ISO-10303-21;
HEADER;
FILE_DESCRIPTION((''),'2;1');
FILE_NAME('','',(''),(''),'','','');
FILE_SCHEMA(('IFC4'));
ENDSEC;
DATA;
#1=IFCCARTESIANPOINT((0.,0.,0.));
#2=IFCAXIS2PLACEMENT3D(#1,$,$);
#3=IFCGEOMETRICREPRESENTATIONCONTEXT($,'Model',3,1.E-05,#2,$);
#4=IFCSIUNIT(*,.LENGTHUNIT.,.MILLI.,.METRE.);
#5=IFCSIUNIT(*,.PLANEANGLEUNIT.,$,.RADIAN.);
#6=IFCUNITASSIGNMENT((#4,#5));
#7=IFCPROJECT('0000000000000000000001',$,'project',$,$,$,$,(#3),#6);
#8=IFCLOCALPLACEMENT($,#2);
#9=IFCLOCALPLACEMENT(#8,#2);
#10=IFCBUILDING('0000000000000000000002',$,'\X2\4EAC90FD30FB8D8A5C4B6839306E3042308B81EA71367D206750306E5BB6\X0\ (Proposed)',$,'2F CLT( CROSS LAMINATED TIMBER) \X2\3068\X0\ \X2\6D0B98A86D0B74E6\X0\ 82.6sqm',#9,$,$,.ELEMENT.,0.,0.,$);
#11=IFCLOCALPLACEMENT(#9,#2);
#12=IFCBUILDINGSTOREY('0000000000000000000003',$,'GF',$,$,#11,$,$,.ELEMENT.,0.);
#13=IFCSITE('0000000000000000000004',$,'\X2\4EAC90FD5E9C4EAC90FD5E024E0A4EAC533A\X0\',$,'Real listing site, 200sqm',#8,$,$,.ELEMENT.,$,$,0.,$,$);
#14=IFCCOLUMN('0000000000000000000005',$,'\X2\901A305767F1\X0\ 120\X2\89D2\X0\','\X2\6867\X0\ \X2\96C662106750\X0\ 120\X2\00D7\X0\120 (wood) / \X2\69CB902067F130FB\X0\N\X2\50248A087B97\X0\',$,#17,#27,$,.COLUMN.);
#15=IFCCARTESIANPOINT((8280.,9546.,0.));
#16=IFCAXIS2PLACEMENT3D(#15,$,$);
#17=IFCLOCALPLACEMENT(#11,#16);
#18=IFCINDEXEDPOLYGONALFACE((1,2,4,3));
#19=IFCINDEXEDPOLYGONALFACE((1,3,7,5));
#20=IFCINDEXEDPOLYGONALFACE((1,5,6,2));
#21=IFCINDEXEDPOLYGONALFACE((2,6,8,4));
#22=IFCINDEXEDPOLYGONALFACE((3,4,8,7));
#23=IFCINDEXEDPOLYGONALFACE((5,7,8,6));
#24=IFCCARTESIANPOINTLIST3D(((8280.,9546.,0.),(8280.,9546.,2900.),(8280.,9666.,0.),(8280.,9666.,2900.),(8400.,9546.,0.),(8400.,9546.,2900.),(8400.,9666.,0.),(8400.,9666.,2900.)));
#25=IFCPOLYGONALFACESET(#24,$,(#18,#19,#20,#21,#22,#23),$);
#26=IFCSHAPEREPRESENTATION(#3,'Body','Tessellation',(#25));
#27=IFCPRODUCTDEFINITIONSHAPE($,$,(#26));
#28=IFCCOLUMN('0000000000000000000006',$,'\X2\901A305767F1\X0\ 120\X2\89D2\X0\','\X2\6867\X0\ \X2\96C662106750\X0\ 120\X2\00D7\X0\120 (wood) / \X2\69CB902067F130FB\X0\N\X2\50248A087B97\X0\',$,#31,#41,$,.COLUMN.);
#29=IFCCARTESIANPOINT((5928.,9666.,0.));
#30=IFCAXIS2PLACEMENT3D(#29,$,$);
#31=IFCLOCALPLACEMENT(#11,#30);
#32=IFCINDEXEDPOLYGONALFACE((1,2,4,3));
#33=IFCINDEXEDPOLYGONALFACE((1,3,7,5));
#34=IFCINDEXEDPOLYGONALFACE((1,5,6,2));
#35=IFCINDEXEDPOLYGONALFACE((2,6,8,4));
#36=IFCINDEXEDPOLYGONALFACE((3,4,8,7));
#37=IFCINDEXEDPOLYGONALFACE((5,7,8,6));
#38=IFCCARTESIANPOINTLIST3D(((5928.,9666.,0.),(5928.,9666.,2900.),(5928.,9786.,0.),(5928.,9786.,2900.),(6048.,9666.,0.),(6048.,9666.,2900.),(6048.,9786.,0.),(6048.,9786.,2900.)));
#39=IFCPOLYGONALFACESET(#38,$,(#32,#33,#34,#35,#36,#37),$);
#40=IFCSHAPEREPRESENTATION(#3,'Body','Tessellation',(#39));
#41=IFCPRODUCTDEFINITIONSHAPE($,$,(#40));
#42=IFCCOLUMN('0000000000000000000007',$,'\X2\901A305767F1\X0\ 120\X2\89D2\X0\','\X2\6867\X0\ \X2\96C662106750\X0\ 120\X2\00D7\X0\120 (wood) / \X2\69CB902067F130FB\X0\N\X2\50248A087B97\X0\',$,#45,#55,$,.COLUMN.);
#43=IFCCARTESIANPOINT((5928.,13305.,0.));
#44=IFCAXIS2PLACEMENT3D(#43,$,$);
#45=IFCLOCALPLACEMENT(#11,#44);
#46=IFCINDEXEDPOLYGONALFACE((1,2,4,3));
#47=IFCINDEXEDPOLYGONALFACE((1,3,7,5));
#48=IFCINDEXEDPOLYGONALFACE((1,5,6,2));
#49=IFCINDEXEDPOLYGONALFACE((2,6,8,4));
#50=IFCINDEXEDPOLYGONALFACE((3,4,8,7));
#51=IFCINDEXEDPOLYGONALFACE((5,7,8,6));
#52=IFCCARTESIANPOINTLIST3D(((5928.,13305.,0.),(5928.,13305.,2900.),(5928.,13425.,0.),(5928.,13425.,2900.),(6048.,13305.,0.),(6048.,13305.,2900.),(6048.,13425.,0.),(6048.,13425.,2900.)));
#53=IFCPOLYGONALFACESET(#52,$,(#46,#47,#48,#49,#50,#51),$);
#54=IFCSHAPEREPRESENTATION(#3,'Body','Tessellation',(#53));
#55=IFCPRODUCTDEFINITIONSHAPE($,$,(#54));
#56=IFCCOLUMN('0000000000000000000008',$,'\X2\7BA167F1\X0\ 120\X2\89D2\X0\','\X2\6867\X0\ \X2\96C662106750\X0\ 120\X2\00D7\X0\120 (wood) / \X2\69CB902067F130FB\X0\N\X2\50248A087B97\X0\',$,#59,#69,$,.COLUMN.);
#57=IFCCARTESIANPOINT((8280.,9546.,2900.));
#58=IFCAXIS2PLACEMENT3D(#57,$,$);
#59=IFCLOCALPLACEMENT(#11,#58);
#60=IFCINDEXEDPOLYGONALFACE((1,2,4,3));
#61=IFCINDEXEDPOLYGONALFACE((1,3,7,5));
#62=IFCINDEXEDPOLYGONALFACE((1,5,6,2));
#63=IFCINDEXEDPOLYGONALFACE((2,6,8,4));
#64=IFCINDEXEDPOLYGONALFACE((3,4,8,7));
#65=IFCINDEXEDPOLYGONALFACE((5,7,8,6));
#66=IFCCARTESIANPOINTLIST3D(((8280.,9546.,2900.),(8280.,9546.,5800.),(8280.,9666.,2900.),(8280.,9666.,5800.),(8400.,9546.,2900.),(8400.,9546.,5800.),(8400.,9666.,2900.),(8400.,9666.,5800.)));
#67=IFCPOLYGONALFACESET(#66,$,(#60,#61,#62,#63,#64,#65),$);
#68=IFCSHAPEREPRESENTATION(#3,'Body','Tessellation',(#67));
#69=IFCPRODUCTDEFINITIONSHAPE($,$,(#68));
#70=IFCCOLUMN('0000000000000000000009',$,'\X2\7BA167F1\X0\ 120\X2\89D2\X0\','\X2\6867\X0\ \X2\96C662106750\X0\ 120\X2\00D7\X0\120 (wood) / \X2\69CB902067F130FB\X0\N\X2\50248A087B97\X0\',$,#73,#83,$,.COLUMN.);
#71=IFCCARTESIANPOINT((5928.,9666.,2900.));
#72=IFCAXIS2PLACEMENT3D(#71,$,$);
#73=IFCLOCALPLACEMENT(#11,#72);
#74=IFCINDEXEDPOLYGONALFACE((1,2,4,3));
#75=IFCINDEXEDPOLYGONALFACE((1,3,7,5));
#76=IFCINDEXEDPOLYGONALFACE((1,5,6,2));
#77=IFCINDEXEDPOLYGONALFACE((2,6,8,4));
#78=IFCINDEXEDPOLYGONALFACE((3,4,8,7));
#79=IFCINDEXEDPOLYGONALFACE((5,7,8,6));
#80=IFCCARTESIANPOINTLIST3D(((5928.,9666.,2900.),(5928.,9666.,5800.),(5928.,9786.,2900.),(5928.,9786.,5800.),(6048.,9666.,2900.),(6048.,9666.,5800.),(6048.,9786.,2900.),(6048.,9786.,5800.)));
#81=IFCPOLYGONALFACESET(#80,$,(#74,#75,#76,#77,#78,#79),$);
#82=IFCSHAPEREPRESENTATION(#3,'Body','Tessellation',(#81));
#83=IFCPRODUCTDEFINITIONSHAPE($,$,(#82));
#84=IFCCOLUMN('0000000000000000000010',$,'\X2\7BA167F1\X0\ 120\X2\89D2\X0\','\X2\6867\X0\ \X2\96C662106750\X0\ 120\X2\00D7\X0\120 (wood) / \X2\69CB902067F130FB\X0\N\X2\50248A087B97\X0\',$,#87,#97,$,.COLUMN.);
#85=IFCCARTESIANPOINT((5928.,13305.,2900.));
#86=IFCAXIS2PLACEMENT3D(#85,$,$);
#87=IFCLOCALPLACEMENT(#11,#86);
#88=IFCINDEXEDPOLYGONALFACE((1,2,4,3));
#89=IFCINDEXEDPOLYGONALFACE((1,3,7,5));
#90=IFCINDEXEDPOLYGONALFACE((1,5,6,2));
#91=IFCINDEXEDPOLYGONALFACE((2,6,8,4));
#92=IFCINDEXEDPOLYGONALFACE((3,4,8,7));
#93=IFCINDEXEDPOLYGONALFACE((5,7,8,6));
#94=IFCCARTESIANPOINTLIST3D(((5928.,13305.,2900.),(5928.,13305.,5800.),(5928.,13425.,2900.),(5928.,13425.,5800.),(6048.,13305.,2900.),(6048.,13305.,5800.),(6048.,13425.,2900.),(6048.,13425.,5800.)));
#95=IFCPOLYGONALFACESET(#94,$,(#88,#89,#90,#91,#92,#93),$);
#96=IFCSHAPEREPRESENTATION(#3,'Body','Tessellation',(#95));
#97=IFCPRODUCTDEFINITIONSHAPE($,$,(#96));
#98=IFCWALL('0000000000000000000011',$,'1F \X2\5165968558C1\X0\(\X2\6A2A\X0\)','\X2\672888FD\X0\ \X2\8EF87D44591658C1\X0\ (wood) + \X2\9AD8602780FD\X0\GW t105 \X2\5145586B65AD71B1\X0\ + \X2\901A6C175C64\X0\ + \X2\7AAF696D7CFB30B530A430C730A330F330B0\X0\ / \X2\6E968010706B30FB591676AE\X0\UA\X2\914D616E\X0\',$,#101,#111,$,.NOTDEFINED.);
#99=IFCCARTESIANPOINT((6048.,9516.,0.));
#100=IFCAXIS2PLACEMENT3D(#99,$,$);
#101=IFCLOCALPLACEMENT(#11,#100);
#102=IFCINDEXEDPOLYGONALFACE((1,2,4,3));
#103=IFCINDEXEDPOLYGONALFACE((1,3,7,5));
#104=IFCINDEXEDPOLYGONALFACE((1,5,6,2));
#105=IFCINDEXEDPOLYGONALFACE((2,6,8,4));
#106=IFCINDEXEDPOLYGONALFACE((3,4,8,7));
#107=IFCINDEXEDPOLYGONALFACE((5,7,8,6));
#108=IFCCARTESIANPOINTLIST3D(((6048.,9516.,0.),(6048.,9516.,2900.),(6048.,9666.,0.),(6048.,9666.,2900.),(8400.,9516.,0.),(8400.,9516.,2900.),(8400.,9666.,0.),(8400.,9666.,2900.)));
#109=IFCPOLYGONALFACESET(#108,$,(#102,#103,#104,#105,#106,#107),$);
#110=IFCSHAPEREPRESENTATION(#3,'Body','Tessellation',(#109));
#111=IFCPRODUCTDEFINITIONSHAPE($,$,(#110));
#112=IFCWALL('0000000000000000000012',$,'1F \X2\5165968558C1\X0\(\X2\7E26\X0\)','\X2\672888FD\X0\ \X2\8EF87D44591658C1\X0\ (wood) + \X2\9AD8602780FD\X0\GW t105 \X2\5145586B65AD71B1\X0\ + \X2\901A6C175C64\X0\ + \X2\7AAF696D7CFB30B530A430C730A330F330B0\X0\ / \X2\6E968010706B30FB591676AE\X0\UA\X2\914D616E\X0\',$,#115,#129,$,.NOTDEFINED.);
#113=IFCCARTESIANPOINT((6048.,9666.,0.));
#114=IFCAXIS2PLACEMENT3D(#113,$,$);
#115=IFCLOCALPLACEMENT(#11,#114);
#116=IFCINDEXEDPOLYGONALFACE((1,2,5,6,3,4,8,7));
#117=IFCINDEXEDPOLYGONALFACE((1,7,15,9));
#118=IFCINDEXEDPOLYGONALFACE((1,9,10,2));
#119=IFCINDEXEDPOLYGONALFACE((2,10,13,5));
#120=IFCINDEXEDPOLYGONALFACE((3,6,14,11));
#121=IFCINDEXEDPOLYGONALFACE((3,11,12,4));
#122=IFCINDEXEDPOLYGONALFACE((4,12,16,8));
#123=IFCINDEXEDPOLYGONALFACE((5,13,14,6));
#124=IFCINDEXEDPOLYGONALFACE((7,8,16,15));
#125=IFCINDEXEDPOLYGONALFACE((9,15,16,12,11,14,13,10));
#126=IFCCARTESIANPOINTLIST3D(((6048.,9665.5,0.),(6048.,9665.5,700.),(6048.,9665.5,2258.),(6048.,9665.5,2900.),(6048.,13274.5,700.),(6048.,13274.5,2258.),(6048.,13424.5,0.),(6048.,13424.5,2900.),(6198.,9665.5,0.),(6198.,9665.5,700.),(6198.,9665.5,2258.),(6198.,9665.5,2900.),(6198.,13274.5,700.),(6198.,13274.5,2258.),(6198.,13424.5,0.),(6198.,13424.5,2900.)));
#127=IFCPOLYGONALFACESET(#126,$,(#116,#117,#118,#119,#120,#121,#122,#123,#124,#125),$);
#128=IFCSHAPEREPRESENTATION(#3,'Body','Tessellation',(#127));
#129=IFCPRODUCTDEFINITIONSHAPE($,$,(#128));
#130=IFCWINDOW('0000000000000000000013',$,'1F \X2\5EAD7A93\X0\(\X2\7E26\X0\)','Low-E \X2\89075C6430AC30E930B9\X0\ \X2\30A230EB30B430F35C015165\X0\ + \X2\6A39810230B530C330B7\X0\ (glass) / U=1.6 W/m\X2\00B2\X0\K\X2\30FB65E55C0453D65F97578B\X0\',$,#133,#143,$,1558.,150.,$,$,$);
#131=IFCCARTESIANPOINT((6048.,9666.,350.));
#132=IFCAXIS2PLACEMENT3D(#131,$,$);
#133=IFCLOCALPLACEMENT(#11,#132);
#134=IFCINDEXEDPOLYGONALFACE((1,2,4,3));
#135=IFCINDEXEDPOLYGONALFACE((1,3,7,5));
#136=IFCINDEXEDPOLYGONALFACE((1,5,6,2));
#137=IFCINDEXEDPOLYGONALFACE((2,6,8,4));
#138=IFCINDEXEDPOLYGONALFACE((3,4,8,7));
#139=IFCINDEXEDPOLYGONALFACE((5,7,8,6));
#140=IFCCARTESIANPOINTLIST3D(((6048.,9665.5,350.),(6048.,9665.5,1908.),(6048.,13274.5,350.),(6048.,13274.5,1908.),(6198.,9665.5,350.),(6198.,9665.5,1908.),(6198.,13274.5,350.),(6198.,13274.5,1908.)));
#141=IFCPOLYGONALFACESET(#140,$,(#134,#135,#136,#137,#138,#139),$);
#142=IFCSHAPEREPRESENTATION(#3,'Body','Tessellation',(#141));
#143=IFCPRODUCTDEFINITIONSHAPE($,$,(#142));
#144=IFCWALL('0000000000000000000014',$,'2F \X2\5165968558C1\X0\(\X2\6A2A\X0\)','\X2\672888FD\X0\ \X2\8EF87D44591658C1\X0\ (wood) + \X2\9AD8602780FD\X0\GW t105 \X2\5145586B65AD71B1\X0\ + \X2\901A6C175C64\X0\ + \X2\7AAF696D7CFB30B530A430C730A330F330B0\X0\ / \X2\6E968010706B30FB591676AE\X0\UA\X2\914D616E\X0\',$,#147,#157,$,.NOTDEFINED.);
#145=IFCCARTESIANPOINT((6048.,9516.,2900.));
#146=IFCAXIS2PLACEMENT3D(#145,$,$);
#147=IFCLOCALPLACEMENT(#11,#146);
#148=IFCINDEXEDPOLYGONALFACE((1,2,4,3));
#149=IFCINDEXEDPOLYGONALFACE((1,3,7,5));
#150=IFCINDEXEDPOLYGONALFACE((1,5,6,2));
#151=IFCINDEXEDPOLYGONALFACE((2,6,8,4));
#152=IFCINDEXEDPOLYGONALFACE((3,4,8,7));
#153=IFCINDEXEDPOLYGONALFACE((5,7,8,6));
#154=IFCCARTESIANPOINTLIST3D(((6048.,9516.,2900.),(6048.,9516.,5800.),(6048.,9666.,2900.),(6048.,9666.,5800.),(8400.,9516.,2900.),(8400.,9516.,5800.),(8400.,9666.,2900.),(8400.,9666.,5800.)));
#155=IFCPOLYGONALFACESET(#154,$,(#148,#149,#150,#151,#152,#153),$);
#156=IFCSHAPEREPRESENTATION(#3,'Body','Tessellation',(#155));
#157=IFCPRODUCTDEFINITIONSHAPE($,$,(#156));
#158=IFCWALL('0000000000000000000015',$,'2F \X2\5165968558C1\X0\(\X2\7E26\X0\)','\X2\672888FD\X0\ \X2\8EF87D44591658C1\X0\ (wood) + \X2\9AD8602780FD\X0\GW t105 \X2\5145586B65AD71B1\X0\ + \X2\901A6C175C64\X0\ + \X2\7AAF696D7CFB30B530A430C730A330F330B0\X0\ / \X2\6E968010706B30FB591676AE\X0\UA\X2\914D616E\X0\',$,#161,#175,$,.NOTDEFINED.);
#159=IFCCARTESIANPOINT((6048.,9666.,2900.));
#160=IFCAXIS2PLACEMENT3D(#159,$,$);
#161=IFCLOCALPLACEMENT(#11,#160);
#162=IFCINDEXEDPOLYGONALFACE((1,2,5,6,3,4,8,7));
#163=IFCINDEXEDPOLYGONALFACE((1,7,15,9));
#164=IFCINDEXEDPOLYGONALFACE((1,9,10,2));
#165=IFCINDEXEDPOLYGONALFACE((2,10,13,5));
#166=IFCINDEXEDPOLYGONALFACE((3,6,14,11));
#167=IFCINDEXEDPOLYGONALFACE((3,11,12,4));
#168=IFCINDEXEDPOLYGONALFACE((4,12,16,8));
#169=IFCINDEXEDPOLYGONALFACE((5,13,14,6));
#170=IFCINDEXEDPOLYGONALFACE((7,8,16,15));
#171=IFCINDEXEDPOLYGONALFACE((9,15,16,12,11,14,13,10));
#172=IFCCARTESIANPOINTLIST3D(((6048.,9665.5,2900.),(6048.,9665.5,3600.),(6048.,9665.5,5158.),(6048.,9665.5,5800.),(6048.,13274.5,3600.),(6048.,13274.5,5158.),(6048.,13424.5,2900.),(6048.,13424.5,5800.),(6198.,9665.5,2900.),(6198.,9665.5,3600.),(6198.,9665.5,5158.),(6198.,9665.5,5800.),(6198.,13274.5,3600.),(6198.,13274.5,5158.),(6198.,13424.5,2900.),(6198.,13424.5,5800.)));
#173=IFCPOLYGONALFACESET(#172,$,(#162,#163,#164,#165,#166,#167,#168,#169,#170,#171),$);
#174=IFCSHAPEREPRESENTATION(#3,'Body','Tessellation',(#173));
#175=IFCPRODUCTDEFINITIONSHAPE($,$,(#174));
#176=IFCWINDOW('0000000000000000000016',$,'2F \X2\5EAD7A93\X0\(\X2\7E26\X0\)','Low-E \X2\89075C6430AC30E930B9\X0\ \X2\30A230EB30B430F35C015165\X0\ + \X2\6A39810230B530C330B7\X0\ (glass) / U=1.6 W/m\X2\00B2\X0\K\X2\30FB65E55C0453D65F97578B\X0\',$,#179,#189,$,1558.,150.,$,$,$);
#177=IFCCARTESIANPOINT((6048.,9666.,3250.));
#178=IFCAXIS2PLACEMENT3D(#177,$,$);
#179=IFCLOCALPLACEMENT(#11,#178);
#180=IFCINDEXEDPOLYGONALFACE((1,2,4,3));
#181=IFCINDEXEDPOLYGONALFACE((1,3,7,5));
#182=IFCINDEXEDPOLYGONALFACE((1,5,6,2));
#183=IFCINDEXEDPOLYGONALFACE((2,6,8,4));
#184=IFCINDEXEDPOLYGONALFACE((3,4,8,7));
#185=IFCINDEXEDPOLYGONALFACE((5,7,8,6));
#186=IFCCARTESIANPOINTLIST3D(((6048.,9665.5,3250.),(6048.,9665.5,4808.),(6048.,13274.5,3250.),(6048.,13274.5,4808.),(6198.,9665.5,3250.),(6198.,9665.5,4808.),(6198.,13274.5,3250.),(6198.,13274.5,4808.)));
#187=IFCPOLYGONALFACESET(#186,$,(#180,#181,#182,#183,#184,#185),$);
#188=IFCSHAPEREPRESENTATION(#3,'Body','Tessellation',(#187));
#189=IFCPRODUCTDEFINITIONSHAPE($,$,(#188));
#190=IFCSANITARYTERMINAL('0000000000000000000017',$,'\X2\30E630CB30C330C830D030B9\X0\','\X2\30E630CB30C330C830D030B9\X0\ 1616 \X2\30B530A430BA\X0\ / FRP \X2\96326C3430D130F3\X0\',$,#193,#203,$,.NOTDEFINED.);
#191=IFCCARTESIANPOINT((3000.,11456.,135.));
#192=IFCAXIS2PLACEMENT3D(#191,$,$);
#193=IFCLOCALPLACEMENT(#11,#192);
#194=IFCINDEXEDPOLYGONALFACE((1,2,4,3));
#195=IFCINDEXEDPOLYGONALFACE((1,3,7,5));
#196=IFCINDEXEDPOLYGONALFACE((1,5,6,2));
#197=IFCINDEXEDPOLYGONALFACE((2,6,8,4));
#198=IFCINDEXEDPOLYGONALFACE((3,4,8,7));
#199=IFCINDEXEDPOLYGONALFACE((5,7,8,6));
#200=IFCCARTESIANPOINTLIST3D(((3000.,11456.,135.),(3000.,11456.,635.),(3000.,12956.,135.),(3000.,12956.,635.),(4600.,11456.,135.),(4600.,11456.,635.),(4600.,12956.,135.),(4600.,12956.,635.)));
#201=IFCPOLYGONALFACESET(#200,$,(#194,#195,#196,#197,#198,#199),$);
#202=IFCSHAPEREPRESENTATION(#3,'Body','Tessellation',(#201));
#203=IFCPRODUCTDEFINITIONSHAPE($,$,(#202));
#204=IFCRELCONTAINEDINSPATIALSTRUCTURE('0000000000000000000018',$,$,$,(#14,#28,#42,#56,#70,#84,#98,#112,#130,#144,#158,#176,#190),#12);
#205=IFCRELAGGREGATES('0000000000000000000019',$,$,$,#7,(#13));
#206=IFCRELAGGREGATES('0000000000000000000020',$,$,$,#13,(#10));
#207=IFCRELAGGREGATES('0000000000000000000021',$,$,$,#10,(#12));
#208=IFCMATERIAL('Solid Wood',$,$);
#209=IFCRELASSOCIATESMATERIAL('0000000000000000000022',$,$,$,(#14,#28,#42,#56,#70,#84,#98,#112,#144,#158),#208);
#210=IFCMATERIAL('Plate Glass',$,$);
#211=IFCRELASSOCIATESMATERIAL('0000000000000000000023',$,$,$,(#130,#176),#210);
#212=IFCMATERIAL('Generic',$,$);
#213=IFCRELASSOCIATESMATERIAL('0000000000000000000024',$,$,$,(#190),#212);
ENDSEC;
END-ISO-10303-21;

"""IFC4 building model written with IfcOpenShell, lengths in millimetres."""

from ifc_helpers import new_model, si_unit, frame, frame_2d, origin, place, context, project, spatial, rectangle, extrude, material, element, fill, save


model = new_model("IFC4")

# Units and contexts
model_context = context("Model", 3, precision=1e-05, world=origin())
ifc_project = project(units=[si_unit("LENGTHUNIT", "METRE", prefix="MILLI"), si_unit("PLANEANGLEUNIT", "RADIAN")], contexts=[model_context])

# Site, building, storey
site_placement = place(None, origin())
site = spatial("IfcSite", under=ifc_project, at=site_placement, Name="京都府京都市上京区", ObjectType="Real listing site, 200sqm", CompositionType="ELEMENT", RefElevation=0.0)
building_placement = place(site_placement, origin())
building = spatial("IfcBuilding", under=site, at=building_placement, Name="京都・越屋根のある自然素材の家 (Proposed)", ObjectType="2F CLT( CROSS LAMINATED TIMBER) と 洋風洋瓦 82.6sqm", CompositionType="ELEMENT", ElevationOfRefHeight=0.0, ElevationOfTerrain=0.0)
storey_placement = place(building_placement, origin())
storey = spatial("IfcBuildingStorey", under=building, at=storey_placement, Name="GF", CompositionType="ELEMENT", Elevation=0.0)

# Columns
ifc_material_1 = material(Name="Solid Wood")
column_1_placement = place(storey_placement, frame((8280.0, 9546.0, 0.0)))
element("IfcColumn", 1, at=column_1_placement, inside=storey, material=ifc_material_1, Name="通し柱 120角", Description="桧 集成材 120×120 (wood) / 構造柱・N値計算", PredefinedType="COLUMN", context=model_context, shape_type="SweptSolid", body=[
    extrude(rectangle(XDim=120.0, YDim=120.0, at=frame_2d((60.0, 60.0))), frame((8280.0, 9546.0, 0.0)), (0.0, 0.0, 1.0), 2900.0),
])
column_2_placement = place(storey_placement, frame((5928.0, 9666.0, 0.0)))
element("IfcColumn", 2, at=column_2_placement, inside=storey, material=ifc_material_1, Name="通し柱 120角", Description="桧 集成材 120×120 (wood) / 構造柱・N値計算", PredefinedType="COLUMN", context=model_context, shape_type="SweptSolid", body=[
    extrude(rectangle(XDim=120.0, YDim=120.0, at=frame_2d((60.0, 60.0))), frame((5928.0, 9666.0, 0.0)), (0.0, 0.0, 1.0), 2900.0),
])
column_3_placement = place(storey_placement, frame((5928.0, 13305.0, 0.0)))
element("IfcColumn", 3, at=column_3_placement, inside=storey, material=ifc_material_1, Name="通し柱 120角", Description="桧 集成材 120×120 (wood) / 構造柱・N値計算", PredefinedType="COLUMN", context=model_context, shape_type="SweptSolid", body=[
    extrude(rectangle(XDim=120.0, YDim=120.0, at=frame_2d((60.0, 60.0))), frame((5928.0, 13305.0, 0.0)), (0.0, 0.0, 1.0), 2900.0),
])
column_4_placement = place(storey_placement, frame((8280.0, 9546.0, 2900.0)))
element("IfcColumn", 4, at=column_4_placement, inside=storey, material=ifc_material_1, Name="管柱 120角", Description="桧 集成材 120×120 (wood) / 構造柱・N値計算", PredefinedType="COLUMN", context=model_context, shape_type="SweptSolid", body=[
    extrude(rectangle(XDim=120.0, YDim=120.0, at=frame_2d((60.0, 60.0))), frame((8280.0, 9546.0, 2900.0)), (0.0, 0.0, 1.0), 2900.0),
])
column_5_placement = place(storey_placement, frame((5928.0, 9666.0, 2900.0)))
element("IfcColumn", 5, at=column_5_placement, inside=storey, material=ifc_material_1, Name="管柱 120角", Description="桧 集成材 120×120 (wood) / 構造柱・N値計算", PredefinedType="COLUMN", context=model_context, shape_type="SweptSolid", body=[
    extrude(rectangle(XDim=120.0, YDim=120.0, at=frame_2d((60.0, 60.0))), frame((5928.0, 9666.0, 2900.0)), (0.0, 0.0, 1.0), 2900.0),
])
column_6_placement = place(storey_placement, frame((5928.0, 13305.0, 2900.0)))
element("IfcColumn", 6, at=column_6_placement, inside=storey, material=ifc_material_1, Name="管柱 120角", Description="桧 集成材 120×120 (wood) / 構造柱・N値計算", PredefinedType="COLUMN", context=model_context, shape_type="SweptSolid", body=[
    extrude(rectangle(XDim=120.0, YDim=120.0, at=frame_2d((60.0, 60.0))), frame((5928.0, 13305.0, 2900.0)), (0.0, 0.0, 1.0), 2900.0),
])

# Wall
wall_1_placement = place(storey_placement, frame((6048.0, 9516.0, 0.0)))
element("IfcWall", 7, at=wall_1_placement, inside=storey, material=ifc_material_1, Name="1F 入隅壁(横)", Description="木製 軸組外壁 (wood) + 高性能GW t105 充填断熱 + 通気層 + 窯業系サイディング / 準耐火・外皮UA配慮", PredefinedType="NOTDEFINED", context=model_context, shape_type="SweptSolid", body=[
    extrude(rectangle(XDim=2352.0, YDim=150.0, at=frame_2d((1176.0, 75.0))), frame((6048.0, 9516.0, 0.0)), (0.0, 0.0, 1.0), 2900.0),
])

# Wall, opening, window
wall_2_placement = place(storey_placement, frame((6048.0, 9666.0, 0.0)))
wall_2 = element("IfcWall", 8, at=wall_2_placement, inside=storey, material=ifc_material_1, Name="1F 入隅壁(縦)", Description="木製 軸組外壁 (wood) + 高性能GW t105 充填断熱 + 通気層 + 窯業系サイディング / 準耐火・外皮UA配慮", PredefinedType="NOTDEFINED", context=model_context, shape_type="SweptSolid", body=[
    extrude(rectangle(XDim=150.0, YDim=3759.0, at=frame_2d((75.0, 1879.0))), frame((6048.0, 9666.0, 0.0)), (0.0, 0.0, 1.0), 2900.0),
])
opening_1_placement = place(storey_placement, frame((6048.0, 9666.0, 350.0)))
opening_1 = element("IfcOpeningElement", 9, at=opening_1_placement, cuts=wall_2, PredefinedType="NOTDEFINED", context=model_context, shape_type="SweptSolid", body=[
    extrude(rectangle(XDim=150.0, YDim=3609.0, at=frame_2d((75.0, 1804.0))), frame((6048.0, 9666.0, 350.0)), (0.0, 0.0, 1.0), 1558.0),
])
ifc_material_2 = material(Name="Plate Glass")
window_1_placement = place(storey_placement, frame((6048.0, 9666.0, 350.0)))
window_1 = element("IfcWindow", 10, at=window_1_placement, inside=storey, material=ifc_material_2, Name="1F 庭窓(縦)", Description="Low-E 複層ガラス アルゴン封入 + 樹脂サッシ (glass) / U=1.6 W/m²K・日射取得型", OverallHeight=1558.0, OverallWidth=150.0, context=model_context, shape_type="SweptSolid", body=[
    extrude(rectangle(XDim=150.0, YDim=3609.0, at=frame_2d((75.0, 1804.0))), frame((6048.0, 9666.0, 350.0)), (0.0, 0.0, 1.0), 1558.0),
])
fill(opening_1, window_1)

# Wall
wall_3_placement = place(storey_placement, frame((6048.0, 9516.0, 2900.0)))
element("IfcWall", 11, at=wall_3_placement, inside=storey, material=ifc_material_1, Name="2F 入隅壁(横)", Description="木製 軸組外壁 (wood) + 高性能GW t105 充填断熱 + 通気層 + 窯業系サイディング / 準耐火・外皮UA配慮", PredefinedType="NOTDEFINED", context=model_context, shape_type="SweptSolid", body=[
    extrude(rectangle(XDim=2352.0, YDim=150.0, at=frame_2d((1176.0, 75.0))), frame((6048.0, 9516.0, 2900.0)), (0.0, 0.0, 1.0), 2900.0),
])

# Wall, opening, window
wall_4_placement = place(storey_placement, frame((6048.0, 9666.0, 2900.0)))
wall_4 = element("IfcWall", 12, at=wall_4_placement, inside=storey, material=ifc_material_1, Name="2F 入隅壁(縦)", Description="木製 軸組外壁 (wood) + 高性能GW t105 充填断熱 + 通気層 + 窯業系サイディング / 準耐火・外皮UA配慮", PredefinedType="NOTDEFINED", context=model_context, shape_type="SweptSolid", body=[
    extrude(rectangle(XDim=150.0, YDim=3759.0, at=frame_2d((75.0, 1879.0))), frame((6048.0, 9666.0, 2900.0)), (0.0, 0.0, 1.0), 2900.0),
])
opening_2_placement = place(storey_placement, frame((6048.0, 9666.0, 3250.0)))
opening_2 = element("IfcOpeningElement", 13, at=opening_2_placement, cuts=wall_4, PredefinedType="NOTDEFINED", context=model_context, shape_type="SweptSolid", body=[
    extrude(rectangle(XDim=150.0, YDim=3609.0, at=frame_2d((75.0, 1804.0))), frame((6048.0, 9666.0, 3250.0)), (0.0, 0.0, 1.0), 1558.0),
])
window_2_placement = place(storey_placement, frame((6048.0, 9666.0, 3250.0)))
window_2 = element("IfcWindow", 14, at=window_2_placement, inside=storey, material=ifc_material_2, Name="2F 庭窓(縦)", Description="Low-E 複層ガラス アルゴン封入 + 樹脂サッシ (glass) / U=1.6 W/m²K・日射取得型", OverallHeight=1558.0, OverallWidth=150.0, context=model_context, shape_type="SweptSolid", body=[
    extrude(rectangle(XDim=150.0, YDim=3609.0, at=frame_2d((75.0, 1804.0))), frame((6048.0, 9666.0, 3250.0)), (0.0, 0.0, 1.0), 1558.0),
])
fill(opening_2, window_2)

# Sanitary terminal
ifc_material_3 = material(Name="Generic")
sanitary_terminal_1_placement = place(storey_placement, frame((3000.0, 11456.0, 135.0)))
element("IfcSanitaryTerminal", 15, at=sanitary_terminal_1_placement, inside=storey, material=ifc_material_3, Name="ユニットバス", Description="ユニットバス 1616 サイズ / FRP 防水パン", PredefinedType="NOTDEFINED", context=model_context, shape_type="SweptSolid", body=[
    extrude(rectangle(XDim=1600.0, YDim=1500.0, at=frame_2d((800.0, 750.0))), frame((3000.0, 11456.0, 135.0)), (0.0, 0.0, 1.0), 500.0),
])

save(model, "model.ifc")
